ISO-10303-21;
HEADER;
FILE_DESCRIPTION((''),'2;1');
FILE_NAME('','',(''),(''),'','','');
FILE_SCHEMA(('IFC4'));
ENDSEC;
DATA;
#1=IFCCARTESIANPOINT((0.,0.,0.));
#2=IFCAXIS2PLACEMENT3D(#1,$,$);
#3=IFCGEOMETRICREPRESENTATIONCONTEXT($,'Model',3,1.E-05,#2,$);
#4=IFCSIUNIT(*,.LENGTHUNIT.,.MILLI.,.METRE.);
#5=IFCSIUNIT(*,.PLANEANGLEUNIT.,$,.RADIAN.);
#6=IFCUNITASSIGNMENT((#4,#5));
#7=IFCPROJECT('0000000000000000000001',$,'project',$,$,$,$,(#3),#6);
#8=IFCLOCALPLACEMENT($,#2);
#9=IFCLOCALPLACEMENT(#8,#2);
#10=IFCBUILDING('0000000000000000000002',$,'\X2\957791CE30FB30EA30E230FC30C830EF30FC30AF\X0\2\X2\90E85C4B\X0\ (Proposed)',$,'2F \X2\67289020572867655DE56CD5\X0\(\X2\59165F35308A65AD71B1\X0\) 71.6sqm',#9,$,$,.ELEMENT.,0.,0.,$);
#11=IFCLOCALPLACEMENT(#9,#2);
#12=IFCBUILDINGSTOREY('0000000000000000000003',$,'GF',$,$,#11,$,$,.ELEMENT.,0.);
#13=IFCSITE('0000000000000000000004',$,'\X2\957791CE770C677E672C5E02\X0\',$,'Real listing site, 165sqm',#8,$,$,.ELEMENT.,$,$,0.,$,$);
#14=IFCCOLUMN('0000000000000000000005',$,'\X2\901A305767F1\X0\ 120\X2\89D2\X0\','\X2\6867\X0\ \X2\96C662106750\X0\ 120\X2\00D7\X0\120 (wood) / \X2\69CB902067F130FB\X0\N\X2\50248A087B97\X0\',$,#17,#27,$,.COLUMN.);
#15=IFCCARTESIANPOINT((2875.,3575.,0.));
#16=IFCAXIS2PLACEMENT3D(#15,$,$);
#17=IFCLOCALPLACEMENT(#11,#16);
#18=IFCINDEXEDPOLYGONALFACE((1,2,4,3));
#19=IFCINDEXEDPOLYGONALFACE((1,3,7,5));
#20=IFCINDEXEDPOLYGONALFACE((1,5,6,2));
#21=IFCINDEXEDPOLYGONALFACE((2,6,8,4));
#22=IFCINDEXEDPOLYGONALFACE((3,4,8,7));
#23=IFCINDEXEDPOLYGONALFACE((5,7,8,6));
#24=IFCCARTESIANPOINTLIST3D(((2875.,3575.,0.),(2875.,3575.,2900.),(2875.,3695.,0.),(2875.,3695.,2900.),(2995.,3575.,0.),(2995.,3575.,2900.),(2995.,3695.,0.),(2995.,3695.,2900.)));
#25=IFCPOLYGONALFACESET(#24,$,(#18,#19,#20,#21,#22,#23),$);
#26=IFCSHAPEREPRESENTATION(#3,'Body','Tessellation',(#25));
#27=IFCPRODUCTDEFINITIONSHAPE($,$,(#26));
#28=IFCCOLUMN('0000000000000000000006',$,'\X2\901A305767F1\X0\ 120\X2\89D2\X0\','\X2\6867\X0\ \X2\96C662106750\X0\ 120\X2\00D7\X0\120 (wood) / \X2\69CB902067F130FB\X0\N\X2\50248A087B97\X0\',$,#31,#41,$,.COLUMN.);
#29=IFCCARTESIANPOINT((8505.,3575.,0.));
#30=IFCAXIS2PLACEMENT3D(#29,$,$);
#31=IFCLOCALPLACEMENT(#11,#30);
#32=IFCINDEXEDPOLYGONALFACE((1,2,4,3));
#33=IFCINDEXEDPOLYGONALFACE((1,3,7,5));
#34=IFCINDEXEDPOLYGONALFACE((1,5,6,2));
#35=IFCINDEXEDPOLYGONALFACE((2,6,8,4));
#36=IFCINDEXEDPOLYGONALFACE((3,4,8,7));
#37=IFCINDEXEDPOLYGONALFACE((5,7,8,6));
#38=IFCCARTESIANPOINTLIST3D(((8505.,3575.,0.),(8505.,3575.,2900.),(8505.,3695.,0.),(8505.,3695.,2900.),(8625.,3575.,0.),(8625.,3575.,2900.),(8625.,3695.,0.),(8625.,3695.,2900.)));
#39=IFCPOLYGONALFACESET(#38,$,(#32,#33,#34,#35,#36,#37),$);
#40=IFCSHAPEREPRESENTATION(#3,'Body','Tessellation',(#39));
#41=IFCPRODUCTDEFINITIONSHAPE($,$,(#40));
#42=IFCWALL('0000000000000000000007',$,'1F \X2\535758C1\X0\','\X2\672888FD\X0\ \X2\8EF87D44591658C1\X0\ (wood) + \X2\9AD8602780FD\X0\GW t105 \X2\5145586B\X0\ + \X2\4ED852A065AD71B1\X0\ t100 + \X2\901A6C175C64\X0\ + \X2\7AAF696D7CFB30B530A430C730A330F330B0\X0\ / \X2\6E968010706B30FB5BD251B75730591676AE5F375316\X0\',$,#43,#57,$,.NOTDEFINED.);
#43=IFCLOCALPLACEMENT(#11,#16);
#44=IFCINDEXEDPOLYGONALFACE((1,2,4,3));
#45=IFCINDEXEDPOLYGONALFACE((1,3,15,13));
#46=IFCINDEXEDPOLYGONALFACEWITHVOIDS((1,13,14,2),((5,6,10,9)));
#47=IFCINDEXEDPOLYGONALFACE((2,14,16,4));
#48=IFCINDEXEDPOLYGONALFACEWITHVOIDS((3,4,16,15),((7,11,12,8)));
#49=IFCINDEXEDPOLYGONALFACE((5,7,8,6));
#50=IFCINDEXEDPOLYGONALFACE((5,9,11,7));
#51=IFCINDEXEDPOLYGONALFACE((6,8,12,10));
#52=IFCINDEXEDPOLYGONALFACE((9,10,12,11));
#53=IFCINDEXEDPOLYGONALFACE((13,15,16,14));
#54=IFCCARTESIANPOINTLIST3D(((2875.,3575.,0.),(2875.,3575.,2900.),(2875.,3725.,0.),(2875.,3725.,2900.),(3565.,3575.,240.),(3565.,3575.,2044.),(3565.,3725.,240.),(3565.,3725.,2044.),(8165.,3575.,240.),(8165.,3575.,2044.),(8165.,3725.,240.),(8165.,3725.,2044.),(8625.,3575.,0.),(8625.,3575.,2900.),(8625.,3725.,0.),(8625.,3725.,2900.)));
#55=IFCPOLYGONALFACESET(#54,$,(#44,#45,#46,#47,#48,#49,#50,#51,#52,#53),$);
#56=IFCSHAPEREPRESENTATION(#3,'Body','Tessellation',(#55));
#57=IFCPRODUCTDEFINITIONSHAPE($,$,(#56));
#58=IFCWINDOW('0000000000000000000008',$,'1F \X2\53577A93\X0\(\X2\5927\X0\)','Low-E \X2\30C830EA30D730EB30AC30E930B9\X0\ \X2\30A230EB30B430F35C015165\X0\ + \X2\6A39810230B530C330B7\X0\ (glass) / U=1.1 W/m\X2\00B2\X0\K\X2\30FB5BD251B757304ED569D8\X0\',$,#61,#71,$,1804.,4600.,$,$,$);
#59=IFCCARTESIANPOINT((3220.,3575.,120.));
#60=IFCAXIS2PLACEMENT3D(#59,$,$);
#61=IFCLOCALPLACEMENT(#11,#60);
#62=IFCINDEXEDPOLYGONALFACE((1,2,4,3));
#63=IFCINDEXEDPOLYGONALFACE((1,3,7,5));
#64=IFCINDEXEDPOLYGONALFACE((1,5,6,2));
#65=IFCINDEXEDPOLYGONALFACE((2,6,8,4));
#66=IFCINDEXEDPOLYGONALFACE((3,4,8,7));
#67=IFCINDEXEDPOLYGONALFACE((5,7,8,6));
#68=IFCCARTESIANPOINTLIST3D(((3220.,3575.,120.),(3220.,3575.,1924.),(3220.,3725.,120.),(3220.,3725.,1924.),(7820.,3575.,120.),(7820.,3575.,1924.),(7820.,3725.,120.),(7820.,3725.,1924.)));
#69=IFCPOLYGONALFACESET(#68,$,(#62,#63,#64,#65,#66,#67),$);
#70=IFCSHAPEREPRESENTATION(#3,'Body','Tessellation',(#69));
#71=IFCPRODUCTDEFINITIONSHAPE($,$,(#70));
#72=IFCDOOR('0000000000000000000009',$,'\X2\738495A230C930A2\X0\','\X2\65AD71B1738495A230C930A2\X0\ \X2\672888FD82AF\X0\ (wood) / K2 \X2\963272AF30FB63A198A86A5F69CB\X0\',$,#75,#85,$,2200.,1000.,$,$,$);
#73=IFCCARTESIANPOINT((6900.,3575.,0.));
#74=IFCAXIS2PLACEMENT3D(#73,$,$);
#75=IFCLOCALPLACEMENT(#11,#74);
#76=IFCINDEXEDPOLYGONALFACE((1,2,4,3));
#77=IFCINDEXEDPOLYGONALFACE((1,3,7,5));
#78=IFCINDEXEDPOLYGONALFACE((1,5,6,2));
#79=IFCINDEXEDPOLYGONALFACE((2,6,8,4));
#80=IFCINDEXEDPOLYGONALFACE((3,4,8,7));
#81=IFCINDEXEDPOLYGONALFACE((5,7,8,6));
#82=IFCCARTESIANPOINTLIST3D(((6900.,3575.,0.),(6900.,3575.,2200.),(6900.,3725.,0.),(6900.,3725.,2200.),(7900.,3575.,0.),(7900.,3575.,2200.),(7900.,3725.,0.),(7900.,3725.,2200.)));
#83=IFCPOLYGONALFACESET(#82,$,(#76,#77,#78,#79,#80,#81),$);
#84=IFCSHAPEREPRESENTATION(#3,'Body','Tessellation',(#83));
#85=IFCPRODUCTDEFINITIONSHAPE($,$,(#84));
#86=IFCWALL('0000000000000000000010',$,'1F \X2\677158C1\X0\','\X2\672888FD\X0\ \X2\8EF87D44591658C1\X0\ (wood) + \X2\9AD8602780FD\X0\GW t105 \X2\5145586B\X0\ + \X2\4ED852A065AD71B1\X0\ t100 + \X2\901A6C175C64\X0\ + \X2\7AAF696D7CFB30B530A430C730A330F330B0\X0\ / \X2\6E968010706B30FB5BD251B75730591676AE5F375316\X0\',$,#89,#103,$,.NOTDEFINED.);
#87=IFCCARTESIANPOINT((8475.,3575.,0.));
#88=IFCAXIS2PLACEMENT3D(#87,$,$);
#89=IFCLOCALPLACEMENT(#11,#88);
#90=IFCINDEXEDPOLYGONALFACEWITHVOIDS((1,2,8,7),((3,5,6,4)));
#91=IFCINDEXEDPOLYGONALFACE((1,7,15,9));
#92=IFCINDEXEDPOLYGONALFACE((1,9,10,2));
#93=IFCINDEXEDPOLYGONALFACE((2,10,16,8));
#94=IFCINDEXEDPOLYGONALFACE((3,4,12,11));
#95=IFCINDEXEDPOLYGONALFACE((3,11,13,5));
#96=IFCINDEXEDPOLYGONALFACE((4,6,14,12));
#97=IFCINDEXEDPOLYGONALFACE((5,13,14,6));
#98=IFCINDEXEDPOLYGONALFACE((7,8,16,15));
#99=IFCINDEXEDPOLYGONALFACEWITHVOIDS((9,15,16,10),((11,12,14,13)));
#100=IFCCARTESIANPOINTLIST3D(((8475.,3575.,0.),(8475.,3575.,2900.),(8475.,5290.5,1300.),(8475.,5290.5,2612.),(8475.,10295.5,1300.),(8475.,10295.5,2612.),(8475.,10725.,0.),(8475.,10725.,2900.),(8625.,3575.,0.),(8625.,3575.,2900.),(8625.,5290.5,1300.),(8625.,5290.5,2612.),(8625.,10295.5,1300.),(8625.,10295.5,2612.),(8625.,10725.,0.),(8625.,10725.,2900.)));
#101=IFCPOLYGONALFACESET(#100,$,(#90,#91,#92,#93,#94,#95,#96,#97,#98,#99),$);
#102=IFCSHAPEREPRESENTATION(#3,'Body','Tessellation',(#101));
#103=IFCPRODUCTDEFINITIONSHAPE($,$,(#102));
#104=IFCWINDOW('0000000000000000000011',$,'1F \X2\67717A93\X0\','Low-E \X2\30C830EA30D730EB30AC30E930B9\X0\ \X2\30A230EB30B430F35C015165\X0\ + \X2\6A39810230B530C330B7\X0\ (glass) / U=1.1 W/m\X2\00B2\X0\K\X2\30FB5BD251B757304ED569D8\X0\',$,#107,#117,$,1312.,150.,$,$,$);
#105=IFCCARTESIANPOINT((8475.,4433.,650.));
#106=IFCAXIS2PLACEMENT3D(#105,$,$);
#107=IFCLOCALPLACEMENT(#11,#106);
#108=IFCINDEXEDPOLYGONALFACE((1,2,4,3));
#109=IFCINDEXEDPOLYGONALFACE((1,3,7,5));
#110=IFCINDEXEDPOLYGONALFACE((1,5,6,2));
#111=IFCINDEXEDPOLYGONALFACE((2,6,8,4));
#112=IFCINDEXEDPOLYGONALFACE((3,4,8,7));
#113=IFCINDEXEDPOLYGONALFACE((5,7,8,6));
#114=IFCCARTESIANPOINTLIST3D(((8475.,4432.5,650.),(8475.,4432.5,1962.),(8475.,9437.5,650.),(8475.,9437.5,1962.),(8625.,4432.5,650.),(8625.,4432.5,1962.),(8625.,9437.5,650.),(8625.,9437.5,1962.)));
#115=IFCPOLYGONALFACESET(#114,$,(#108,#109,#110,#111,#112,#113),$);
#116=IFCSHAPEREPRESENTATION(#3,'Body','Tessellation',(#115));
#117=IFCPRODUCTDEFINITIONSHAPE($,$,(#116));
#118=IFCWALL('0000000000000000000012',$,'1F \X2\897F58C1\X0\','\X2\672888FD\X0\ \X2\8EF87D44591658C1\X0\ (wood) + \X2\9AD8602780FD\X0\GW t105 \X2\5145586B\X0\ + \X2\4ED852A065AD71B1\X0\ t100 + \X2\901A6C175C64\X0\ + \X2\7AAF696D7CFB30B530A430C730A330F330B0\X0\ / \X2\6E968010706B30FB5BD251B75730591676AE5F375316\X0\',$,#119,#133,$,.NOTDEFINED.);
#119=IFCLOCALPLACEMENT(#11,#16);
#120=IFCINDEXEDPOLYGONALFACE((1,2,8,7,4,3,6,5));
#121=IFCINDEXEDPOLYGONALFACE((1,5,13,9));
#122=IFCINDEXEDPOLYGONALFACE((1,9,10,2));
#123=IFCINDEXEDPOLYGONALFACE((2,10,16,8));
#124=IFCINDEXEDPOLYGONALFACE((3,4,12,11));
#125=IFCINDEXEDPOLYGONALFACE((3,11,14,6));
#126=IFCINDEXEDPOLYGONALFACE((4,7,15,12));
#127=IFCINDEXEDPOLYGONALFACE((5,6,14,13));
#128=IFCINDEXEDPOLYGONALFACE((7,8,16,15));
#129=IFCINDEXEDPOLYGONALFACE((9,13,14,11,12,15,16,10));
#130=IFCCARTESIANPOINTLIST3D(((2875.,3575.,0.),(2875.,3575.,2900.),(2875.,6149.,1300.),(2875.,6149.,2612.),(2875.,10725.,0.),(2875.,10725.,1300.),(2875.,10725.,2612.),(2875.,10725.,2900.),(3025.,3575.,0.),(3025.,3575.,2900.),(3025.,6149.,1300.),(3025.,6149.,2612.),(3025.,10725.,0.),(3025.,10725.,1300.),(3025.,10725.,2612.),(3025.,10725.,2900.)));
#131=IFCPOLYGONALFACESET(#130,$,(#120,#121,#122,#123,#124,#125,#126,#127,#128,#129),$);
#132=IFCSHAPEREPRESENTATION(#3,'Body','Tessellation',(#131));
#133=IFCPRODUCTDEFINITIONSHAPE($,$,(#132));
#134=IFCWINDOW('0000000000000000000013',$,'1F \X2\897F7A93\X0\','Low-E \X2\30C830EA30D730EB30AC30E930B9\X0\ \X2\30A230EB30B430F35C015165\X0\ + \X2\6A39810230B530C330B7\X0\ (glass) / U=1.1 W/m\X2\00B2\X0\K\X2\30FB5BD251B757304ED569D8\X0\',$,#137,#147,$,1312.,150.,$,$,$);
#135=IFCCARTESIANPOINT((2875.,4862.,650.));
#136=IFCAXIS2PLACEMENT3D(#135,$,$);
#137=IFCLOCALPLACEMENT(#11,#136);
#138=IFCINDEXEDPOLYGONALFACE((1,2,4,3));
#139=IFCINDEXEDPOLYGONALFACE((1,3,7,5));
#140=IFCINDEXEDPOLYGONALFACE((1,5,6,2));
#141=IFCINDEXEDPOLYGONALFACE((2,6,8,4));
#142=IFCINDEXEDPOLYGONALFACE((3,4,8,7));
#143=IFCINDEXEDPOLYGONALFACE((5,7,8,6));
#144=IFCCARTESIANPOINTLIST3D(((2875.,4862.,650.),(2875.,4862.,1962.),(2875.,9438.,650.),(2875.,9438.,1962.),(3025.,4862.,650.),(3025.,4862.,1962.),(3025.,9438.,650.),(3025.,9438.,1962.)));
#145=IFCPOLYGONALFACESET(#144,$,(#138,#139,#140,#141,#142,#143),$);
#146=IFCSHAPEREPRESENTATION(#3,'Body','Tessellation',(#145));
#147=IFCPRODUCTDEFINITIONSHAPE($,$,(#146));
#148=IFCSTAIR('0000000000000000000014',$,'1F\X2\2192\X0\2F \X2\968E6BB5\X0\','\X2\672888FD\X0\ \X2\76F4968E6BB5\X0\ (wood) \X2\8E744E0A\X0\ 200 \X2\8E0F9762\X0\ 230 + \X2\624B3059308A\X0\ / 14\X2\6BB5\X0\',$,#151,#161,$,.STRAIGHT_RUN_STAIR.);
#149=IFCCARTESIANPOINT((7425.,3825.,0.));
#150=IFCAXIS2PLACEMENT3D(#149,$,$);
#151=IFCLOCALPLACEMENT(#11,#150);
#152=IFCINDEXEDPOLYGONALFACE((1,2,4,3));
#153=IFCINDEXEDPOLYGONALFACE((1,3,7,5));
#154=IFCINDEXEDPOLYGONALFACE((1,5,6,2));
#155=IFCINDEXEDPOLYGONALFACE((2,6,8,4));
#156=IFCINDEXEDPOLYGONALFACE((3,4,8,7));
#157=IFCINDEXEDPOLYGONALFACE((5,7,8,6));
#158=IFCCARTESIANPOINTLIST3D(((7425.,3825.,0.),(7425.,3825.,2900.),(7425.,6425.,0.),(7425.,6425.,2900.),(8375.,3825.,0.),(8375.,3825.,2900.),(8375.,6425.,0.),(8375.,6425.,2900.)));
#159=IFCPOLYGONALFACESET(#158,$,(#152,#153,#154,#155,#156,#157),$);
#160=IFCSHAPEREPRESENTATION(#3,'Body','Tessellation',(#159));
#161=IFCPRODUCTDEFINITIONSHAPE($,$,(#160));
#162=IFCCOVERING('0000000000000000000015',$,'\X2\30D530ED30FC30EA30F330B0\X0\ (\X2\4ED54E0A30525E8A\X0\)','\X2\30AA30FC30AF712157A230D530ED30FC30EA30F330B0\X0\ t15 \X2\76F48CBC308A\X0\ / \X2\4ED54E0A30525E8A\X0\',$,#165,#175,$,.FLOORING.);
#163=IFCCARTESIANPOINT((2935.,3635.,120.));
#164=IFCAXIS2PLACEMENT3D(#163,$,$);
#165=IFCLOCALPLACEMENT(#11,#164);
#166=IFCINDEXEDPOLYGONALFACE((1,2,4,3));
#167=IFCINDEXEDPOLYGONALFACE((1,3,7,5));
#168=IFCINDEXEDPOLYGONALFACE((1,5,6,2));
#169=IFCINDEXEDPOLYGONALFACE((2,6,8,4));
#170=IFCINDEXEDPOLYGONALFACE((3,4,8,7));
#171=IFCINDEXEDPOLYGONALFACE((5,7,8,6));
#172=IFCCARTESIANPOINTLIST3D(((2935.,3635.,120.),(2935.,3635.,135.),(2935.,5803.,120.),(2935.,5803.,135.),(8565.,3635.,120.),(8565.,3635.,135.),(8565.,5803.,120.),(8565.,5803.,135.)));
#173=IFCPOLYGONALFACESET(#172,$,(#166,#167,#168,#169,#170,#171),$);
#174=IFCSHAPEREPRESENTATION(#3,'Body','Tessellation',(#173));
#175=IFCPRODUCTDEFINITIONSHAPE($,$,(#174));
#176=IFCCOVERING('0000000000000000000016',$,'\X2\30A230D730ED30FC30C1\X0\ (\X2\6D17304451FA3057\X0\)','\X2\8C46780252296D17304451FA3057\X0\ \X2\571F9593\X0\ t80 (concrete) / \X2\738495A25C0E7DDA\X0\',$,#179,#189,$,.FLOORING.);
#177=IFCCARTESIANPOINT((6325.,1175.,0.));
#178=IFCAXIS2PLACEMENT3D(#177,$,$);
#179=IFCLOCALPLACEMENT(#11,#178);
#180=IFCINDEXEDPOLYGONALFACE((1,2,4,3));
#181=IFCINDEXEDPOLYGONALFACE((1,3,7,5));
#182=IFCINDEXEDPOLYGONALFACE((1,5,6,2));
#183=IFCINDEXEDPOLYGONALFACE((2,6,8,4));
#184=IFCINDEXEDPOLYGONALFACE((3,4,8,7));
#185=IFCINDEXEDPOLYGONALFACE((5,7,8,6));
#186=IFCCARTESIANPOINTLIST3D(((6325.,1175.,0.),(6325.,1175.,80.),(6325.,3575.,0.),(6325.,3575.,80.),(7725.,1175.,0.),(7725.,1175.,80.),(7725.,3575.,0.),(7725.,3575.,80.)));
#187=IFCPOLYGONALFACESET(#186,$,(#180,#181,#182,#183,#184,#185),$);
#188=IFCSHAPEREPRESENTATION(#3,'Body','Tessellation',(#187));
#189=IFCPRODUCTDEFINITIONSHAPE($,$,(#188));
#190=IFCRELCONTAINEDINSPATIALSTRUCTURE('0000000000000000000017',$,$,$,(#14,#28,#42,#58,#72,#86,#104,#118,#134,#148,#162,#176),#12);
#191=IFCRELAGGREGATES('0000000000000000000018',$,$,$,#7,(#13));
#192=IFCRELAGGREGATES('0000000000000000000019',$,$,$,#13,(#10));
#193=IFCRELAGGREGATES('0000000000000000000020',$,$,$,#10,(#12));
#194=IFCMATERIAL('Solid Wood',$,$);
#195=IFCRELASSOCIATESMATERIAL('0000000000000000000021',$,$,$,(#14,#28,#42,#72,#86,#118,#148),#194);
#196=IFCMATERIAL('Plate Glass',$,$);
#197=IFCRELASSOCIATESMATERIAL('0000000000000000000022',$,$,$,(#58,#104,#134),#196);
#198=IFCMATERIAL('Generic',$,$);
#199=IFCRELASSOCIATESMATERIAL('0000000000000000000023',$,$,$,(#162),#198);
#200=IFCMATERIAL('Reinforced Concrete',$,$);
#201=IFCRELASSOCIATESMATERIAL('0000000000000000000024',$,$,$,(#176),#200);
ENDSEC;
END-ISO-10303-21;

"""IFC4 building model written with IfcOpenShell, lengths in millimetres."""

from ifc_helpers import new_model, si_unit, frame, frame_2d, origin, place, context, project, spatial, rectangle, extrude, material, element, fill, save


model = new_model("IFC4")

# Units and contexts
model_context = context("Model", 3, precision=1e-05, world=origin())
ifc_project = project(units=[si_unit("LENGTHUNIT", "METRE", prefix="MILLI"), si_unit("PLANEANGLEUNIT", "RADIAN")], contexts=[model_context])

# Site, building, storey
site_placement = place(None, origin())
site = spatial("IfcSite", under=ifc_project, at=site_placement, Name="長野県松本市", ObjectType="Real listing site, 165sqm", CompositionType="ELEMENT", RefElevation=0.0)
building_placement = place(site_placement, origin())
building = spatial("IfcBuilding", under=site, at=building_placement, Name="長野・リモートワーク2部屋 (Proposed)", ObjectType="2F 木造在来工法(外張り断熱) 71.6sqm", CompositionType="ELEMENT", ElevationOfRefHeight=0.0, ElevationOfTerrain=0.0)
storey_placement = place(building_placement, origin())
storey = spatial("IfcBuildingStorey", under=building, at=storey_placement, Name="GF", CompositionType="ELEMENT", Elevation=0.0)

# Columns
ifc_material_1 = material(Name="Solid Wood")
column_1_placement = place(storey_placement, frame((2875.0, 3575.0, 0.0)))
element("IfcColumn", 1, at=column_1_placement, inside=storey, material=ifc_material_1, Name="通し柱 120角", Description="桧 集成材 120×120 (wood) / 構造柱・N値計算", PredefinedType="COLUMN", context=model_context, shape_type="SweptSolid", body=[
    extrude(rectangle(XDim=120.0, YDim=120.0, at=frame_2d((60.0, 60.0))), frame((2875.0, 3575.0, 0.0)), (0.0, 0.0, 1.0), 2900.0),
])
column_2_placement = place(storey_placement, frame((8505.0, 3575.0, 0.0)))
element("IfcColumn", 2, at=column_2_placement, inside=storey, material=ifc_material_1, Name="通し柱 120角", Description="桧 集成材 120×120 (wood) / 構造柱・N値計算", PredefinedType="COLUMN", context=model_context, shape_type="SweptSolid", body=[
    extrude(rectangle(XDim=120.0, YDim=120.0, at=frame_2d((60.0, 60.0))), frame((8505.0, 3575.0, 0.0)), (0.0, 0.0, 1.0), 2900.0),
])

# Shared definitions
ifc_material_2 = material(Name="Reinforced Concrete")

# Wall, openings, window, door
wall_1_placement = place(storey_placement, frame((2875.0, 3575.0, 0.0)))
wall_1 = element("IfcWall", 3, at=wall_1_placement, inside=storey, material=ifc_material_1, Name="1F 南壁", Description="木製 軸組外壁 (wood) + 高性能GW t105 充填 + 付加断熱 t100 + 通気層 + 窯業系サイディング / 準耐火・寒冷地外皮強化", PredefinedType="NOTDEFINED", context=model_context, shape_type="SweptSolid", body=[
    extrude(rectangle(XDim=5750.0, YDim=150.0, at=frame_2d((2875.0, 75.0))), frame((2875.0, 3575.0, 0.0)), (0.0, 0.0, 1.0), 2900.0),
])
opening_1_placement = place(storey_placement, frame((3220.0, 3575.0, 120.0)))
opening_1 = element("IfcOpeningElement", 4, at=opening_1_placement, cuts=wall_1, PredefinedType="NOTDEFINED", context=model_context, shape_type="SweptSolid", body=[
    extrude(rectangle(XDim=4600.0, YDim=150.0, at=frame_2d((2300.0, 75.0))), frame((3220.0, 3575.0, 120.0)), (0.0, 0.0, 1.0), 1804.0),
])
opening_2_placement = place(storey_placement, frame((6900.0, 3575.0, 0.0)))
opening_2 = element("IfcOpeningElement", 5, at=opening_2_placement, cuts=wall_1, PredefinedType="NOTDEFINED", context=model_context, shape_type="SweptSolid", body=[
    extrude(rectangle(XDim=1000.0, YDim=150.0, at=frame_2d((500.0, 75.0))), frame((6900.0, 3575.0, 0.0)), (0.0, 0.0, 1.0), 2200.0),
])
ifc_material_3 = material(Name="Plate Glass")
window_1_placement = place(storey_placement, frame((3220.0, 3575.0, 120.0)))
window_1 = element("IfcWindow", 6, at=window_1_placement, inside=storey, material=ifc_material_3, Name="1F 南窓(大)", Description="Low-E トリプルガラス アルゴン封入 + 樹脂サッシ (glass) / U=1.1 W/m²K・寒冷地仕様", OverallHeight=1804.0, OverallWidth=4600.0, context=model_context, shape_type="SweptSolid", body=[
    extrude(rectangle(XDim=4600.0, YDim=150.0, at=frame_2d((2300.0, 75.0))), frame((3220.0, 3575.0, 120.0)), (0.0, 0.0, 1.0), 1804.0),
])
fill(opening_1, window_1)
door_placement = place(storey_placement, frame((6900.0, 3575.0, 0.0)))
door = element("IfcDoor", 7, at=door_placement, inside=storey, material=ifc_material_1, Name="玄関ドア", Description="断熱玄関ドア 木製芯 (wood) / K2 防犯・採風機構", OverallHeight=2200.0, OverallWidth=1000.0, context=model_context, shape_type="SweptSolid", body=[
    extrude(rectangle(XDim=1000.0, YDim=150.0, at=frame_2d((500.0, 75.0))), frame((6900.0, 3575.0, 0.0)), (0.0, 0.0, 1.0), 2200.0),
])
fill(opening_2, door)

# Walls, openings, windows
wall_2_placement = place(storey_placement, frame((8475.0, 3575.0, 0.0)))
wall_2 = element("IfcWall", 8, at=wall_2_placement, inside=storey, material=ifc_material_1, Name="1F 東壁", Description="木製 軸組外壁 (wood) + 高性能GW t105 充填 + 付加断熱 t100 + 通気層 + 窯業系サイディング / 準耐火・寒冷地外皮強化", PredefinedType="NOTDEFINED", context=model_context, shape_type="SweptSolid", body=[
    extrude(rectangle(XDim=150.0, YDim=7150.0, at=frame_2d((75.0, 3575.0))), frame((8475.0, 3575.0, 0.0)), (0.0, 0.0, 1.0), 2900.0),
])
opening_3_placement = place(storey_placement, frame((8475.0, 4433.0, 650.0)))
opening_3 = element("IfcOpeningElement", 9, at=opening_3_placement, cuts=wall_2, PredefinedType="NOTDEFINED", context=model_context, shape_type="SweptSolid", body=[
    extrude(rectangle(XDim=150.0, YDim=5005.0, at=frame_2d((75.0, 2502.0))), frame((8475.0, 4433.0, 650.0)), (0.0, 0.0, 1.0), 1312.0),
])
window_2_placement = place(storey_placement, frame((8475.0, 4433.0, 650.0)))
window_2 = element("IfcWindow", 10, at=window_2_placement, inside=storey, material=ifc_material_3, Name="1F 東窓", Description="Low-E トリプルガラス アルゴン封入 + 樹脂サッシ (glass) / U=1.1 W/m²K・寒冷地仕様", OverallHeight=1312.0, OverallWidth=150.0, context=model_context, shape_type="SweptSolid", body=[
    extrude(rectangle(XDim=150.0, YDim=5005.0, at=frame_2d((75.0, 2502.0))), frame((8475.0, 4433.0, 650.0)), (0.0, 0.0, 1.0), 1312.0),
])
fill(opening_3, window_2)
wall_3_placement = place(storey_placement, frame((2875.0, 3575.0, 0.0)))
wall_3 = element("IfcWall", 11, at=wall_3_placement, inside=storey, material=ifc_material_1, Name="1F 西壁", Description="木製 軸組外壁 (wood) + 高性能GW t105 充填 + 付加断熱 t100 + 通気層 + 窯業系サイディング / 準耐火・寒冷地外皮強化", PredefinedType="NOTDEFINED", context=model_context, shape_type="SweptSolid", body=[
    extrude(rectangle(XDim=150.0, YDim=7150.0, at=frame_2d((75.0, 3575.0))), frame((2875.0, 3575.0, 0.0)), (0.0, 0.0, 1.0), 2900.0),
])
opening_4_placement = place(storey_placement, frame((2875.0, 4862.0, 650.0)))
opening_4 = element("IfcOpeningElement", 12, at=opening_4_placement, cuts=wall_3, PredefinedType="NOTDEFINED", context=model_context, shape_type="SweptSolid", body=[
    extrude(rectangle(XDim=150.0, YDim=4576.0, at=frame_2d((75.0, 2288.0))), frame((2875.0, 4862.0, 650.0)), (0.0, 0.0, 1.0), 1312.0),
])
window_3_placement = place(storey_placement, frame((2875.0, 4862.0, 650.0)))
window_3 = element("IfcWindow", 13, at=window_3_placement, inside=storey, material=ifc_material_3, Name="1F 西窓", Description="Low-E トリプルガラス アルゴン封入 + 樹脂サッシ (glass) / U=1.1 W/m²K・寒冷地仕様", OverallHeight=1312.0, OverallWidth=150.0, context=model_context, shape_type="SweptSolid", body=[
    extrude(rectangle(XDim=150.0, YDim=4576.0, at=frame_2d((75.0, 2288.0))), frame((2875.0, 4862.0, 650.0)), (0.0, 0.0, 1.0), 1312.0),
])
fill(opening_4, window_3)

# Stair
stair_placement = place(storey_placement, frame((7425.0, 3825.0, 0.0)))
element("IfcStair", 14, at=stair_placement, inside=storey, material=ifc_material_1, Name="1F→2F 階段", Description="木製 直階段 (wood) 蹴上 200 踏面 230 + 手すり / 14段", PredefinedType="STRAIGHT_RUN_STAIR", context=model_context, shape_type="SweptSolid", body=[
    extrude(rectangle(XDim=950.0, YDim=2600.0, at=frame_2d((475.0, 1300.0))), frame((7425.0, 3825.0, 0.0)), (0.0, 0.0, 1.0), 2900.0),
])

# Coverings
ifc_material_4 = material(Name="Generic")
covering_1_placement = place(storey_placement, frame((2935.0, 3635.0, 120.0)))
element("IfcCovering", 15, at=covering_1_placement, inside=storey, material=ifc_material_4, Name="フローリング (仕上げ床)", Description="オーク無垢フローリング t15 直貼り / 仕上げ床", PredefinedType="FLOORING", context=model_context, shape_type="SweptSolid", body=[
    extrude(rectangle(XDim=5630.0, YDim=2168.0, at=frame_2d((2815.0, 1084.0))), frame((2935.0, 3635.0, 120.0)), (0.0, 0.0, 1.0), 15.0),
])
covering_2_placement = place(storey_placement, frame((6325.0, 1175.0, 0.0)))
element("IfcCovering", 16, at=covering_2_placement, inside=storey, material=ifc_material_2, Name="アプローチ (洗い出し)", Description="豆砂利洗い出し 土間 t80 (concrete) / 玄関導線", PredefinedType="FLOORING", context=model_context, shape_type="SweptSolid", body=[
    extrude(rectangle(XDim=1400.0, YDim=2400.0, at=frame_2d((700.0, 1200.0))), frame((6325.0, 1175.0, 0.0)), (0.0, 0.0, 1.0), 80.0),
])

save(model, "model.ifc")
